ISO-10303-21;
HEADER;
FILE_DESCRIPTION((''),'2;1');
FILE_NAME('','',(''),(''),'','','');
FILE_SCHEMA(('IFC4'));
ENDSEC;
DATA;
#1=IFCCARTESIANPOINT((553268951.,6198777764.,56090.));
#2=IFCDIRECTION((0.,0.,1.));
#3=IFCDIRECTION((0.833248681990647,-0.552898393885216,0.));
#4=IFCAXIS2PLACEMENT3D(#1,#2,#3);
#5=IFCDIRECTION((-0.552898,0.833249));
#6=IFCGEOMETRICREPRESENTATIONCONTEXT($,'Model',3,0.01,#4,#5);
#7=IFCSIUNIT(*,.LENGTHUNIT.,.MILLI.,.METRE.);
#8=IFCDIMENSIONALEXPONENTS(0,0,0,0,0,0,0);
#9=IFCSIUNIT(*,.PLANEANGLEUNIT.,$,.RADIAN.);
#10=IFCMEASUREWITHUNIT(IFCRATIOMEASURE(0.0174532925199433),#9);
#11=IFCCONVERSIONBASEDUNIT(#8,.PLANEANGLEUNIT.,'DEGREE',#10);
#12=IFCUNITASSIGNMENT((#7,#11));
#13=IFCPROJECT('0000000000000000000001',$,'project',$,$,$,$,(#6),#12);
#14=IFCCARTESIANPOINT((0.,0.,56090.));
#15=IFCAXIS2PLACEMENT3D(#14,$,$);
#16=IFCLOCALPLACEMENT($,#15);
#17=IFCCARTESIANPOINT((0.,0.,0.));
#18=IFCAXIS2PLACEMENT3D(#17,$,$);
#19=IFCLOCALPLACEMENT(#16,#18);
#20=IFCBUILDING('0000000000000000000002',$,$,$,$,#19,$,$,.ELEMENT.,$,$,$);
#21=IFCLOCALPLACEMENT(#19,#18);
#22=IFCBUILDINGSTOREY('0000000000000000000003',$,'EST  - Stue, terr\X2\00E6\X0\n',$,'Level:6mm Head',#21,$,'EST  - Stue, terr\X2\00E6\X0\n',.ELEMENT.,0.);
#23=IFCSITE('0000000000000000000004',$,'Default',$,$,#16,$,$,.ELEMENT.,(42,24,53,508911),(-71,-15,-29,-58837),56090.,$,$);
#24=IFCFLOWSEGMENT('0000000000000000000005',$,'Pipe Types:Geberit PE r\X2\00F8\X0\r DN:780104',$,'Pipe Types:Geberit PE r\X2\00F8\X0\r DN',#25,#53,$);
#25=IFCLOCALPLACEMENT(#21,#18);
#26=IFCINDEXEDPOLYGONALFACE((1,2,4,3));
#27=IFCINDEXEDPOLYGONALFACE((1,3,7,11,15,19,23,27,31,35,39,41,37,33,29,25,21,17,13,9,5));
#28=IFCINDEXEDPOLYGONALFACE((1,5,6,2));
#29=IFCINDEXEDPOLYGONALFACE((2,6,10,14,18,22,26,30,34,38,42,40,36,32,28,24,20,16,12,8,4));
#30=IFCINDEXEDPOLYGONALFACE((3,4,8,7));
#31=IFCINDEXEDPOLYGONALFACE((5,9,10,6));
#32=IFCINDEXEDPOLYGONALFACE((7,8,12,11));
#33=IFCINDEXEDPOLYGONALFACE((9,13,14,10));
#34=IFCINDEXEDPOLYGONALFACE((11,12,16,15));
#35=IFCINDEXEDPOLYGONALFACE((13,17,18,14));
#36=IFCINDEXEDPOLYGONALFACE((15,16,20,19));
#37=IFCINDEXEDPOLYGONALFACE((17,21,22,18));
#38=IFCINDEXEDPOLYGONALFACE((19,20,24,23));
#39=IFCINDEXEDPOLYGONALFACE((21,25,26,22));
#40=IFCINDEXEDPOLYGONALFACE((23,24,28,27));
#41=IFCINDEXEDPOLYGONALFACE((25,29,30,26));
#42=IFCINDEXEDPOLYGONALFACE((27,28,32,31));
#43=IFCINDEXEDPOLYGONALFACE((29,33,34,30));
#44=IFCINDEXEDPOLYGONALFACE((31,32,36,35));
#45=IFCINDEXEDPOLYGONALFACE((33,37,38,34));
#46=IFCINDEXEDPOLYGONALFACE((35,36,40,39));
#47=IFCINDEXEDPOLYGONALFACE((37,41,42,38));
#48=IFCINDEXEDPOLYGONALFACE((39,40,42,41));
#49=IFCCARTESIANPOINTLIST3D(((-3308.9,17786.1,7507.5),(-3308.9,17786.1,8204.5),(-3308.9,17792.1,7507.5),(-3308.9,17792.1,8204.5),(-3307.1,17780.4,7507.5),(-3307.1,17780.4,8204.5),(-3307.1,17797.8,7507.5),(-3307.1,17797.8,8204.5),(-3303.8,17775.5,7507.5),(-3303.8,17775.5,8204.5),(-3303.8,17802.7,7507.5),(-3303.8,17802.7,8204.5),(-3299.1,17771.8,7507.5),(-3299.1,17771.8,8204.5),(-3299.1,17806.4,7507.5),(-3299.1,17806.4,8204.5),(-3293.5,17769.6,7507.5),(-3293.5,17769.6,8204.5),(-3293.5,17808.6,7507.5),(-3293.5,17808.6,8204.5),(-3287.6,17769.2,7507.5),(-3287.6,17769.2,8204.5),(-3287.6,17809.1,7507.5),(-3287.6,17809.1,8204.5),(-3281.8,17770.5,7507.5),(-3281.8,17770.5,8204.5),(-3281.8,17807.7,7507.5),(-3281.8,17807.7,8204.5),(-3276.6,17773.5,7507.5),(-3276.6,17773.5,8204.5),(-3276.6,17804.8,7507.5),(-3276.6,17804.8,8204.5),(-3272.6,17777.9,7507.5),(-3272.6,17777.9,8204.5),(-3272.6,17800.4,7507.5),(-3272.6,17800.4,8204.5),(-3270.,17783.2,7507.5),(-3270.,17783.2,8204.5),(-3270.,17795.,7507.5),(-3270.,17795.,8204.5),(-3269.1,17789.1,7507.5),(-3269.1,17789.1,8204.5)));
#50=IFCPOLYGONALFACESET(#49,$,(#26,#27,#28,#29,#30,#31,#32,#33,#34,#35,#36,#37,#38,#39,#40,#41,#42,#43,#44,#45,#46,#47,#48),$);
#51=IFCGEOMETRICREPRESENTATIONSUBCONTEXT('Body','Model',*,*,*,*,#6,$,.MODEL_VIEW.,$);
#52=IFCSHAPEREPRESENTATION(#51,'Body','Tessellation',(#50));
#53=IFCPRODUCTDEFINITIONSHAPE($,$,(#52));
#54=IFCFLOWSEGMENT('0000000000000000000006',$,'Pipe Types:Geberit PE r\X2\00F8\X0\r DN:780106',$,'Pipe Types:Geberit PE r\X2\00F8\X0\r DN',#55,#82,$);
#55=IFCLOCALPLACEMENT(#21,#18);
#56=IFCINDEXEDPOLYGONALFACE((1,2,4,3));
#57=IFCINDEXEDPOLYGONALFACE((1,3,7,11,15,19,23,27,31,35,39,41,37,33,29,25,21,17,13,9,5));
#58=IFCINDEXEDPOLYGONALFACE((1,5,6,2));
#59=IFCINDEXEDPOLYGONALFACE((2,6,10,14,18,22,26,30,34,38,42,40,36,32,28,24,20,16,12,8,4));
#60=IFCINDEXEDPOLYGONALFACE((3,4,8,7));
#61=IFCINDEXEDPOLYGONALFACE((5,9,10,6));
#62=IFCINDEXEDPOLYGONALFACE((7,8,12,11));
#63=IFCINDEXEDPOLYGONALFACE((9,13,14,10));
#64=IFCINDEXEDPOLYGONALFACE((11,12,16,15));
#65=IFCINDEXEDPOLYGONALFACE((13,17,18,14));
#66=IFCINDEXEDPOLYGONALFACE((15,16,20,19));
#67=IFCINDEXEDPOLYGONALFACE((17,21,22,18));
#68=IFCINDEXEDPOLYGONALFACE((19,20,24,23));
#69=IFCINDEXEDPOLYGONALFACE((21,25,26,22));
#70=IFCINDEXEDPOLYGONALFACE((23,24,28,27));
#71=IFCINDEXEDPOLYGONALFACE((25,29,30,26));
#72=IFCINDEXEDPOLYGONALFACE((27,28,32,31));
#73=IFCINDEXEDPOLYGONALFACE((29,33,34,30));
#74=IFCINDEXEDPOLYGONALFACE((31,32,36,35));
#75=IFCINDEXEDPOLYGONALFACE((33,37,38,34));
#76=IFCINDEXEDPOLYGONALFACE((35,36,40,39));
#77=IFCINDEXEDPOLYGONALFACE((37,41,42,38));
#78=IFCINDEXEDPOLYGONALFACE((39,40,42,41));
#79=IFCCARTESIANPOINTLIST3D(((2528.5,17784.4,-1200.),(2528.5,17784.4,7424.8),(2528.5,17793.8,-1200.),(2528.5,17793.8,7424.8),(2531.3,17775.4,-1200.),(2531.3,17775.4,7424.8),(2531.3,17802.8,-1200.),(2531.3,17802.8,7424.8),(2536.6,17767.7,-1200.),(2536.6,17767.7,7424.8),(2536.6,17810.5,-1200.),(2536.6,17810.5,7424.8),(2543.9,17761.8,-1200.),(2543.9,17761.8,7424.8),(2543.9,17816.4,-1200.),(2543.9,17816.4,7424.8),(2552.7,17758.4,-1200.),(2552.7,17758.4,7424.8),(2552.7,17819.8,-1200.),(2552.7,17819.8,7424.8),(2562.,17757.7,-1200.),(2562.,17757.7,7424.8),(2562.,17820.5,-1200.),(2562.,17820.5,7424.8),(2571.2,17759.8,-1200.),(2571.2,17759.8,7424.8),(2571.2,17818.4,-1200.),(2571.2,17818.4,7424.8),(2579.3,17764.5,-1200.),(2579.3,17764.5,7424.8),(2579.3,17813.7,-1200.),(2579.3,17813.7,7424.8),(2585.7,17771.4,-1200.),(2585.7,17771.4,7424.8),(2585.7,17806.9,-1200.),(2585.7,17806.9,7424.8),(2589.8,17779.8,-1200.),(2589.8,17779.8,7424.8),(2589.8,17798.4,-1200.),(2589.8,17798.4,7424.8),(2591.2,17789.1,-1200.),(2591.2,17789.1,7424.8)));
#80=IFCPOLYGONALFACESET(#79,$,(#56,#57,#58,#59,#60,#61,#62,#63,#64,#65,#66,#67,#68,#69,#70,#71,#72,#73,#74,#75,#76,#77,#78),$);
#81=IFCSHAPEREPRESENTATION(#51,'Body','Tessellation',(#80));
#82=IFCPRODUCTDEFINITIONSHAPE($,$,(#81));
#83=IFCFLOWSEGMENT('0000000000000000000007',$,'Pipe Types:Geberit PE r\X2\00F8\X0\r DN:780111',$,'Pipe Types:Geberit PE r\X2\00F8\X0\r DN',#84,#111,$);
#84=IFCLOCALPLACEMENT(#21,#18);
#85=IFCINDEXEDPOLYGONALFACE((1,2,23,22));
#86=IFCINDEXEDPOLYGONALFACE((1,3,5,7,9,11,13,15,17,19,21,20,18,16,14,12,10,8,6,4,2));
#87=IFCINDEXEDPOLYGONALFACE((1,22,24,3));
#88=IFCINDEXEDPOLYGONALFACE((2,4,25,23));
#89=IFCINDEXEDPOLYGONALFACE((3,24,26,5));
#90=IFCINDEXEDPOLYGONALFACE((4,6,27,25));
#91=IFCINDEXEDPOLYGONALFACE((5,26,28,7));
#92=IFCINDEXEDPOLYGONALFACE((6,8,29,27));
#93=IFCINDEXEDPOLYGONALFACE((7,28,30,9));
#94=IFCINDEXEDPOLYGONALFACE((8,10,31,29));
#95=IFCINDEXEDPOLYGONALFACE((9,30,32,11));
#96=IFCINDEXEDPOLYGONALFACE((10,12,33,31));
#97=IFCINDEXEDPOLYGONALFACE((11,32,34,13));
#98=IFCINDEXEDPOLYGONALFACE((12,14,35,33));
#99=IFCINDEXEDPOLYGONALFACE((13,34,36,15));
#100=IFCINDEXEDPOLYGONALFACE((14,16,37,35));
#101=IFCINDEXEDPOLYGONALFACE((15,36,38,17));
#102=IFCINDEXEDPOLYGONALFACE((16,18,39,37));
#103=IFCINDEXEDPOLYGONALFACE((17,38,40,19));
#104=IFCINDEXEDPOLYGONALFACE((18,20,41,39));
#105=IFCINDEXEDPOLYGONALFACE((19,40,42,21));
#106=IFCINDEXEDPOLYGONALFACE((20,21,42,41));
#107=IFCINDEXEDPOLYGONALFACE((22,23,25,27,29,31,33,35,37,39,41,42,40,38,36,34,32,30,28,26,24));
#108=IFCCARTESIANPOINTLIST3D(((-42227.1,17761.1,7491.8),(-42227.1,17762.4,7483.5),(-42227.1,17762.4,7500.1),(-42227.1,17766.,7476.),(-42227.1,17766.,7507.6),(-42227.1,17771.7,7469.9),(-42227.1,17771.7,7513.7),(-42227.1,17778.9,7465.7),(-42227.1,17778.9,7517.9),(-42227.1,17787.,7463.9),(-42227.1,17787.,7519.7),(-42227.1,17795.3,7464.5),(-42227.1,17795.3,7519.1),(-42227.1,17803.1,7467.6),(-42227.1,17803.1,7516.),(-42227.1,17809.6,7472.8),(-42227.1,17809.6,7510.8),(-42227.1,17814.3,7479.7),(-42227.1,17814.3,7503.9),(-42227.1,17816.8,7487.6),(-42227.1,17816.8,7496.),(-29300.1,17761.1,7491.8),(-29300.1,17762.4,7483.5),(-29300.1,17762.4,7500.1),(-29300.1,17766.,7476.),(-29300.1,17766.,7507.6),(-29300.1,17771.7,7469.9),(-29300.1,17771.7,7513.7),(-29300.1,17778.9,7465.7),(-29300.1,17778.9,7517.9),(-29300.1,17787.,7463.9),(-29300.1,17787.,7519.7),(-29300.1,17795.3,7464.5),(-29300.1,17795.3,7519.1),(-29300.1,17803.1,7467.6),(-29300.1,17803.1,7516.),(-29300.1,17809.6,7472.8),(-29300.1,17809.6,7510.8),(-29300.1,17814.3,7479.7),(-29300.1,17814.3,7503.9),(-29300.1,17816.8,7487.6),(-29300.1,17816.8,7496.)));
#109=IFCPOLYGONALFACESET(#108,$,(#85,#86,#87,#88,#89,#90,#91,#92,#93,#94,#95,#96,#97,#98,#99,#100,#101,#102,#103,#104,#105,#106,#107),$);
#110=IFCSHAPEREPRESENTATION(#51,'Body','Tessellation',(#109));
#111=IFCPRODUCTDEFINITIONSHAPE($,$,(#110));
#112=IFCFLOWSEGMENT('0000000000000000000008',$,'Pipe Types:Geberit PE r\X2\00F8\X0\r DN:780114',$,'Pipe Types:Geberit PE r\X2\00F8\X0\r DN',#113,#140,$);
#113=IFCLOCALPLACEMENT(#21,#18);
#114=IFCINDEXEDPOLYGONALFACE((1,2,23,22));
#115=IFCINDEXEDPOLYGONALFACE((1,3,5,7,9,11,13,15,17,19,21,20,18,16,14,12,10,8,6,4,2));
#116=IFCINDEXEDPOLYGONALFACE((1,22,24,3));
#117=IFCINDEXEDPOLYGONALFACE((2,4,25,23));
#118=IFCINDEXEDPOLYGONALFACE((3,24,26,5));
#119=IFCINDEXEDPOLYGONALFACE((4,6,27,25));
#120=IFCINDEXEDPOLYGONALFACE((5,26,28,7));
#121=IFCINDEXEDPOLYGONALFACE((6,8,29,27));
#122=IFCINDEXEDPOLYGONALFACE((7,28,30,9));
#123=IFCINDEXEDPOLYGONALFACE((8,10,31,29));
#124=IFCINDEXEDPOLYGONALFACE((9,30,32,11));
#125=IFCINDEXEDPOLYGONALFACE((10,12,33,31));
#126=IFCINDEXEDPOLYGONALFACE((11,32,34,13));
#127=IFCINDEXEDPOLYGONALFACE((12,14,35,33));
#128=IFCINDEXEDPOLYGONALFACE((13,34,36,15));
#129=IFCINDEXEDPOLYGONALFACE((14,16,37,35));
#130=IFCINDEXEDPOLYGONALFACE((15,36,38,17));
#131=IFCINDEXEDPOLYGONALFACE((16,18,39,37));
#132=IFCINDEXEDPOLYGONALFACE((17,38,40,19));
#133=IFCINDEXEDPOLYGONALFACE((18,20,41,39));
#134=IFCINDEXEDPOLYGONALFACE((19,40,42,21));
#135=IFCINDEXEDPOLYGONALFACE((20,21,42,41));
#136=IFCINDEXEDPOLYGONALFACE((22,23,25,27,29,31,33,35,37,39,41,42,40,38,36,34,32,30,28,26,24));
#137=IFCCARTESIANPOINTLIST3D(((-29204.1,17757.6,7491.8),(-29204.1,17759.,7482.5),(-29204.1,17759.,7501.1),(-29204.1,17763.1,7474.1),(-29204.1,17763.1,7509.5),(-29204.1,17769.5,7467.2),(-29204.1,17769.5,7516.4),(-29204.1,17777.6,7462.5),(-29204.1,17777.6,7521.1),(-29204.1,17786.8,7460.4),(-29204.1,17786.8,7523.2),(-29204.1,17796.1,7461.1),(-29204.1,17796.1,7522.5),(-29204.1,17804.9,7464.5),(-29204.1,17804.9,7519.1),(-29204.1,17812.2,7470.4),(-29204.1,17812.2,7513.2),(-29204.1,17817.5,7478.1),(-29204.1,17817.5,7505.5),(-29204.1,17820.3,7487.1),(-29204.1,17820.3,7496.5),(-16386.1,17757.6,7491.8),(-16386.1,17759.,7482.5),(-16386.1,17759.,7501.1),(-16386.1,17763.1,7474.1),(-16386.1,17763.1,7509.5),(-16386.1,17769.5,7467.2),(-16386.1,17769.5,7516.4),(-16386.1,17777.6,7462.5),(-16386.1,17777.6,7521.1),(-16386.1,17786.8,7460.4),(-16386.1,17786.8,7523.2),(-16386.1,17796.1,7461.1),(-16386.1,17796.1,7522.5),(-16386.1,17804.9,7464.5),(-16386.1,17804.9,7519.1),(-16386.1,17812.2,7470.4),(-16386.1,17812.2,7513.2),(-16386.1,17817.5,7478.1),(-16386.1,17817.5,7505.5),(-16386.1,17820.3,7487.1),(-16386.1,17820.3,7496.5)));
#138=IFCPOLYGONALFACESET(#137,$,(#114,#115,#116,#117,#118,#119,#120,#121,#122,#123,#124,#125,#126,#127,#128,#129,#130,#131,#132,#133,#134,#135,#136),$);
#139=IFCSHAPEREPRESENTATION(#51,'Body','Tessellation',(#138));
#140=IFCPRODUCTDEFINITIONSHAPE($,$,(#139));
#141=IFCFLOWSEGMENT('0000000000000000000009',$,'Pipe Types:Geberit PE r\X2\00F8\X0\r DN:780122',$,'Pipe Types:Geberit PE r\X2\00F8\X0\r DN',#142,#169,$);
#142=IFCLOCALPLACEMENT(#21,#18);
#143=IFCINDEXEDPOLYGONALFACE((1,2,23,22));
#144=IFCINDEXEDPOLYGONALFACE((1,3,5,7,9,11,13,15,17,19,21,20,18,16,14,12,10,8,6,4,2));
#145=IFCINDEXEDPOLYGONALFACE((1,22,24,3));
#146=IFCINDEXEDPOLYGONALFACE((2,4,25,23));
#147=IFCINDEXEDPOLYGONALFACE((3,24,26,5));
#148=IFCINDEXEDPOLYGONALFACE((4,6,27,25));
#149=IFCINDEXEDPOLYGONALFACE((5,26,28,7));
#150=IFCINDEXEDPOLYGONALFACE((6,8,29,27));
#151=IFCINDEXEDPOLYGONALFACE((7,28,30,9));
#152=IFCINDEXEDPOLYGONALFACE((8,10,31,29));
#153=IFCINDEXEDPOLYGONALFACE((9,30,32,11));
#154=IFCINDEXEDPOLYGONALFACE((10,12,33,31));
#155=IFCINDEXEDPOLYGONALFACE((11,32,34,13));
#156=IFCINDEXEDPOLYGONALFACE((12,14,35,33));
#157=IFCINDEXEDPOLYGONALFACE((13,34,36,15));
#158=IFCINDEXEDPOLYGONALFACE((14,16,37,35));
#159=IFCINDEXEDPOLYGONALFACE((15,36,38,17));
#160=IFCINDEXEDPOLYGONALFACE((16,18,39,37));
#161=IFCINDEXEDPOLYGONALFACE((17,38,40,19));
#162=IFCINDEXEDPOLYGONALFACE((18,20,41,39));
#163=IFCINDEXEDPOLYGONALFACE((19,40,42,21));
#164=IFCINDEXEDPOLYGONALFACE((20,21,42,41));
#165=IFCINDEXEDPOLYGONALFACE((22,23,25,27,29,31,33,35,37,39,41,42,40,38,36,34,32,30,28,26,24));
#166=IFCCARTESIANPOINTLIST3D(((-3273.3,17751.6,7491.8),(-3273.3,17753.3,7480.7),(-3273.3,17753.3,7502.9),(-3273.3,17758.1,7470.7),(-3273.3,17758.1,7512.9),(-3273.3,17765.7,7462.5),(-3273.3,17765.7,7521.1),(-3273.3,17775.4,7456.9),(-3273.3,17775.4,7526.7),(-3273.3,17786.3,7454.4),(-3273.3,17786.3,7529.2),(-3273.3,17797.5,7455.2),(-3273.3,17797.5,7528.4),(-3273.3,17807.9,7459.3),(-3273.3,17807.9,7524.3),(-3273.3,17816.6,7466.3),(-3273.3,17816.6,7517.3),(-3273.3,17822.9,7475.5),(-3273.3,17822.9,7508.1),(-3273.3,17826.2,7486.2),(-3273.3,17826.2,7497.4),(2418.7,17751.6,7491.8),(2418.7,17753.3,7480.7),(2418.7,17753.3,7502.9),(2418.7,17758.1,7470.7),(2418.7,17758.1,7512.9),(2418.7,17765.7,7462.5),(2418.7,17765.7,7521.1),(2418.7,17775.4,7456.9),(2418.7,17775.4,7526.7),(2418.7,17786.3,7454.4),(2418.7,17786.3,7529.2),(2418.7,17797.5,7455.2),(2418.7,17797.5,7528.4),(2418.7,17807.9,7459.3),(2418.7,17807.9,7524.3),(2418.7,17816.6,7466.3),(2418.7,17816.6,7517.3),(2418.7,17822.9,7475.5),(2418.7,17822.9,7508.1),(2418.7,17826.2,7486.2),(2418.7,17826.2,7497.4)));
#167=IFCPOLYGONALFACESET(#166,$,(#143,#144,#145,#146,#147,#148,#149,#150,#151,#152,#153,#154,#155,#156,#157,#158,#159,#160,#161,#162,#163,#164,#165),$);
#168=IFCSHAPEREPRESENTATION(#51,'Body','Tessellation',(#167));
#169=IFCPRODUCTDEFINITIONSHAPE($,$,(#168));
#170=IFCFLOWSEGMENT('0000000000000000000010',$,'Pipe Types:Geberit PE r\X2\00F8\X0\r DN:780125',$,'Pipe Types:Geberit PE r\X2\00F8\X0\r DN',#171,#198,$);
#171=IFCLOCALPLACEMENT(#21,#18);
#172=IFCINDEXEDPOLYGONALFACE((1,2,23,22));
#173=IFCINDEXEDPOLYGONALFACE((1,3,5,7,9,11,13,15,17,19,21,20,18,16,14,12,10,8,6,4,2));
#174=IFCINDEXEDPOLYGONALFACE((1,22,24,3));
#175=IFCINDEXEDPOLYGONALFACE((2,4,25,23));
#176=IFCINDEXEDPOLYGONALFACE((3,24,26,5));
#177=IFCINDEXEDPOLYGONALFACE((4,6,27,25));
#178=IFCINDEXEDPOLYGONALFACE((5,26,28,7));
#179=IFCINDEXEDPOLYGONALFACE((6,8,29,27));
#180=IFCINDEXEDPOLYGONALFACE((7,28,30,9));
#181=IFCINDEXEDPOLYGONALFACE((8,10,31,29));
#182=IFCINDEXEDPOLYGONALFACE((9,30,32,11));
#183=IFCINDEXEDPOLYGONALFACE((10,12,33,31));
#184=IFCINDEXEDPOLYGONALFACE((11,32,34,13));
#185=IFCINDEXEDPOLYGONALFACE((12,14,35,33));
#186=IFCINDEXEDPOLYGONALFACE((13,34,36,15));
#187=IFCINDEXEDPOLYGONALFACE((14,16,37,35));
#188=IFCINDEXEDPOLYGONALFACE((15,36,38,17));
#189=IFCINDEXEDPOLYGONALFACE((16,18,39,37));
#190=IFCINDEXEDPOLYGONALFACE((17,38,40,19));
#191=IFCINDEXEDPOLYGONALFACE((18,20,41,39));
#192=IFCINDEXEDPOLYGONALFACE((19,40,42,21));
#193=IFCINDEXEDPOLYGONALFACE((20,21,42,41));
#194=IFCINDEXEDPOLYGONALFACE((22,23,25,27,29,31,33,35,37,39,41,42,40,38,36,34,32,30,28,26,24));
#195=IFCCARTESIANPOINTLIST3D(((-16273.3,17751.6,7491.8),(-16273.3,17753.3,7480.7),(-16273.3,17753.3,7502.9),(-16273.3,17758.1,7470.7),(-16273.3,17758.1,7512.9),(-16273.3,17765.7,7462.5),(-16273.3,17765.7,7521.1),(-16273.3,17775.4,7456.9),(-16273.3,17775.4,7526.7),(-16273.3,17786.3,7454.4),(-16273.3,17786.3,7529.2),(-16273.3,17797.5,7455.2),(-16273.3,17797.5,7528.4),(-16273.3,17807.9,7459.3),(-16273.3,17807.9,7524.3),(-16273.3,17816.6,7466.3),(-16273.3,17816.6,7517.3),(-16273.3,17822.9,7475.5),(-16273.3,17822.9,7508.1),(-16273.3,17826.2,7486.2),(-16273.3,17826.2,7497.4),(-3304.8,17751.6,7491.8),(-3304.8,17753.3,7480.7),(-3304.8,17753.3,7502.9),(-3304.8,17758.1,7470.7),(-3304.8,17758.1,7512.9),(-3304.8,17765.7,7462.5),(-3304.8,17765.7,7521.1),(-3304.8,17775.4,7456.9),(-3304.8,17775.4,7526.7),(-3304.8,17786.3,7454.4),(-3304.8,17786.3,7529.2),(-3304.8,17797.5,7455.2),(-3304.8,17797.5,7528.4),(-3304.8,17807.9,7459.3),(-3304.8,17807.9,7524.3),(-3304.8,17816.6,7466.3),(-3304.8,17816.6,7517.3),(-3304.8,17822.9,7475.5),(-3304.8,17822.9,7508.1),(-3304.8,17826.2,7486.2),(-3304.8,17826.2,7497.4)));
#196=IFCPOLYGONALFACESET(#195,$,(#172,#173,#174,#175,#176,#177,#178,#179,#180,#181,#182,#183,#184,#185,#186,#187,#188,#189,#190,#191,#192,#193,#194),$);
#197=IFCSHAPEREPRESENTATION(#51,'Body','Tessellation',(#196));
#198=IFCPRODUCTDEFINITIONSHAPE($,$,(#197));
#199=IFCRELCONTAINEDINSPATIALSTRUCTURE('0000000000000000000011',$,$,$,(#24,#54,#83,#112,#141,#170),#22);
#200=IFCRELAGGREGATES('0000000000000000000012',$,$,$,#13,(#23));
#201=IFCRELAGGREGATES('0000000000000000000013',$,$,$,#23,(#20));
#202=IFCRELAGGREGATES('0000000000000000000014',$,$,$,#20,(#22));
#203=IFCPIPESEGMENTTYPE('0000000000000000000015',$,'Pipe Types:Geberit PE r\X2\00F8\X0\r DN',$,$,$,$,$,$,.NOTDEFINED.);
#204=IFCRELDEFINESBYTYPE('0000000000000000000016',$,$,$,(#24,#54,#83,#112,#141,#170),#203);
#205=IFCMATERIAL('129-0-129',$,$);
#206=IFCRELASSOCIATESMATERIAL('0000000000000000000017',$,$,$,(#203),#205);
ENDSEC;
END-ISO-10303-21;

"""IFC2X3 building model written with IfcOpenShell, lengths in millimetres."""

from ifc_helpers import new_model, entity, si_unit, converted_unit, direction, frame, origin, origin_2d_with_axis, place, context, subcontext, project, spatial, circle, extrude, material, type_object, element, save


model = new_model("IFC2X3")

# Units and contexts
model_context = context("Model", 3, precision=0.01, world=frame((553268951.0, 6198777764.0, 56090.0), z_axis=(0.0, 0.0, 1.0), x_axis=(0.833248681990647, -0.552898393885216, 0.0)), true_north=direction((-0.552898, 0.833249)))
body_context = subcontext(model_context, "Body", "Model", "MODEL_VIEW")
ifc_project = project(units=[si_unit("LENGTHUNIT", "METRE", prefix="MILLI"), converted_unit("PLANEANGLEUNIT", "DEGREE", entity("IfcRatioMeasure", 0.0174532925199433), si_unit("PLANEANGLEUNIT", "RADIAN"), dimensions=[0, 0, 0, 0, 0, 0, 0])], contexts=[model_context])

# Site, building, storey
site_placement = place(None, frame((0.0, 0.0, 56090.0)))
site = spatial("IfcSite", under=ifc_project, at=site_placement, Name="Default", CompositionType="ELEMENT", RefLatitude=(42, 24, 53, 508911), RefLongitude=(-71, -15, -29, -58837), RefElevation=56090.0)
building_placement = place(site_placement, origin())
building = spatial("IfcBuilding", under=site, at=building_placement, CompositionType="ELEMENT")
storey_placement = place(building_placement, frame((0.0, 0.0, 0.0)))
storey = spatial("IfcBuildingStorey", under=building, at=storey_placement, Name="EST  - Stue, terræn", ObjectType="Level:6mm Head", LongName="EST  - Stue, terræn", CompositionType="ELEMENT", Elevation=0.0)

# Flow segments
ifc_material_1 = material(Name="129-0-129")
pipe_segment_type_1 = type_object("IfcPipeSegmentType", Name="Pipe Types:Geberit PE rør DN", PredefinedType="NOTDEFINED", material=ifc_material_1)
flow_segment_1_placement = place(storey_placement, origin())
element("IfcFlowSegment", 1, at=flow_segment_1_placement, inside=storey, type_object=pipe_segment_type_1, Name="Pipe Types:Geberit PE rør DN:780104", ObjectType="Pipe Types:Geberit PE rør DN", context=body_context, shape_type="SweptSolid", body=[
    extrude(circle(Radius=20.0, at=origin_2d_with_axis()), frame((-3289.1, 17789.1, 7507.5)), (0.0, 0.0, 1.0), 696.9),
])
flow_segment_2_placement = place(storey_placement, origin())
element("IfcFlowSegment", 2, at=flow_segment_2_placement, inside=storey, type_object=pipe_segment_type_1, Name="Pipe Types:Geberit PE rør DN:780106", ObjectType="Pipe Types:Geberit PE rør DN", context=body_context, shape_type="SweptSolid", body=[
    extrude(circle(Radius=31.5, at=origin_2d_with_axis()), frame((2559.7, 17789.1, -1200.0)), (0.0, 0.0, 1.0), 8624.8),
])
flow_segment_3_placement = place(storey_placement, origin())
element("IfcFlowSegment", 3, at=flow_segment_3_placement, inside=storey, type_object=pipe_segment_type_1, Name="Pipe Types:Geberit PE rør DN:780111", ObjectType="Pipe Types:Geberit PE rør DN", context=body_context, shape_type="SweptSolid", body=[
    extrude(circle(Radius=28.0, at=origin_2d_with_axis()), frame((-42227.1, 17789.1, 7491.8), z_axis=(1.0, 0.0, 0.0), x_axis=(0.0, -1.0, 0.0)), (0.0, 0.0, 1.0), 12927.0),
])
flow_segment_4_placement = place(storey_placement, origin())
element("IfcFlowSegment", 4, at=flow_segment_4_placement, inside=storey, type_object=pipe_segment_type_1, Name="Pipe Types:Geberit PE rør DN:780114", ObjectType="Pipe Types:Geberit PE rør DN", context=body_context, shape_type="SweptSolid", body=[
    extrude(circle(Radius=31.5, at=origin_2d_with_axis()), frame((-29204.1, 17789.1, 7491.8), z_axis=(1.0, 0.0, 0.0), x_axis=(0.0, -1.0, 0.0)), (0.0, 0.0, 1.0), 12818.0),
])
flow_segment_5_placement = place(storey_placement, origin())
element("IfcFlowSegment", 5, at=flow_segment_5_placement, inside=storey, type_object=pipe_segment_type_1, Name="Pipe Types:Geberit PE rør DN:780122", ObjectType="Pipe Types:Geberit PE rør DN", context=body_context, shape_type="SweptSolid", body=[
    extrude(circle(Radius=37.5, at=origin_2d_with_axis()), frame((-3273.3, 17789.1, 7491.8), z_axis=(1.0, 0.0, 0.0), x_axis=(0.0, -1.0, 0.0)), (0.0, 0.0, 1.0), 5692.0),
])
flow_segment_6_placement = place(storey_placement, origin())
element("IfcFlowSegment", 6, at=flow_segment_6_placement, inside=storey, type_object=pipe_segment_type_1, Name="Pipe Types:Geberit PE rør DN:780125", ObjectType="Pipe Types:Geberit PE rør DN", context=body_context, shape_type="SweptSolid", body=[
    extrude(circle(Radius=37.5, at=origin_2d_with_axis()), frame((-16273.3, 17789.1, 7491.8), z_axis=(1.0, 0.0, 0.0), x_axis=(0.0, -1.0, 0.0)), (0.0, 0.0, 1.0), 12968.5),
])

save(model, "model.ifc")
